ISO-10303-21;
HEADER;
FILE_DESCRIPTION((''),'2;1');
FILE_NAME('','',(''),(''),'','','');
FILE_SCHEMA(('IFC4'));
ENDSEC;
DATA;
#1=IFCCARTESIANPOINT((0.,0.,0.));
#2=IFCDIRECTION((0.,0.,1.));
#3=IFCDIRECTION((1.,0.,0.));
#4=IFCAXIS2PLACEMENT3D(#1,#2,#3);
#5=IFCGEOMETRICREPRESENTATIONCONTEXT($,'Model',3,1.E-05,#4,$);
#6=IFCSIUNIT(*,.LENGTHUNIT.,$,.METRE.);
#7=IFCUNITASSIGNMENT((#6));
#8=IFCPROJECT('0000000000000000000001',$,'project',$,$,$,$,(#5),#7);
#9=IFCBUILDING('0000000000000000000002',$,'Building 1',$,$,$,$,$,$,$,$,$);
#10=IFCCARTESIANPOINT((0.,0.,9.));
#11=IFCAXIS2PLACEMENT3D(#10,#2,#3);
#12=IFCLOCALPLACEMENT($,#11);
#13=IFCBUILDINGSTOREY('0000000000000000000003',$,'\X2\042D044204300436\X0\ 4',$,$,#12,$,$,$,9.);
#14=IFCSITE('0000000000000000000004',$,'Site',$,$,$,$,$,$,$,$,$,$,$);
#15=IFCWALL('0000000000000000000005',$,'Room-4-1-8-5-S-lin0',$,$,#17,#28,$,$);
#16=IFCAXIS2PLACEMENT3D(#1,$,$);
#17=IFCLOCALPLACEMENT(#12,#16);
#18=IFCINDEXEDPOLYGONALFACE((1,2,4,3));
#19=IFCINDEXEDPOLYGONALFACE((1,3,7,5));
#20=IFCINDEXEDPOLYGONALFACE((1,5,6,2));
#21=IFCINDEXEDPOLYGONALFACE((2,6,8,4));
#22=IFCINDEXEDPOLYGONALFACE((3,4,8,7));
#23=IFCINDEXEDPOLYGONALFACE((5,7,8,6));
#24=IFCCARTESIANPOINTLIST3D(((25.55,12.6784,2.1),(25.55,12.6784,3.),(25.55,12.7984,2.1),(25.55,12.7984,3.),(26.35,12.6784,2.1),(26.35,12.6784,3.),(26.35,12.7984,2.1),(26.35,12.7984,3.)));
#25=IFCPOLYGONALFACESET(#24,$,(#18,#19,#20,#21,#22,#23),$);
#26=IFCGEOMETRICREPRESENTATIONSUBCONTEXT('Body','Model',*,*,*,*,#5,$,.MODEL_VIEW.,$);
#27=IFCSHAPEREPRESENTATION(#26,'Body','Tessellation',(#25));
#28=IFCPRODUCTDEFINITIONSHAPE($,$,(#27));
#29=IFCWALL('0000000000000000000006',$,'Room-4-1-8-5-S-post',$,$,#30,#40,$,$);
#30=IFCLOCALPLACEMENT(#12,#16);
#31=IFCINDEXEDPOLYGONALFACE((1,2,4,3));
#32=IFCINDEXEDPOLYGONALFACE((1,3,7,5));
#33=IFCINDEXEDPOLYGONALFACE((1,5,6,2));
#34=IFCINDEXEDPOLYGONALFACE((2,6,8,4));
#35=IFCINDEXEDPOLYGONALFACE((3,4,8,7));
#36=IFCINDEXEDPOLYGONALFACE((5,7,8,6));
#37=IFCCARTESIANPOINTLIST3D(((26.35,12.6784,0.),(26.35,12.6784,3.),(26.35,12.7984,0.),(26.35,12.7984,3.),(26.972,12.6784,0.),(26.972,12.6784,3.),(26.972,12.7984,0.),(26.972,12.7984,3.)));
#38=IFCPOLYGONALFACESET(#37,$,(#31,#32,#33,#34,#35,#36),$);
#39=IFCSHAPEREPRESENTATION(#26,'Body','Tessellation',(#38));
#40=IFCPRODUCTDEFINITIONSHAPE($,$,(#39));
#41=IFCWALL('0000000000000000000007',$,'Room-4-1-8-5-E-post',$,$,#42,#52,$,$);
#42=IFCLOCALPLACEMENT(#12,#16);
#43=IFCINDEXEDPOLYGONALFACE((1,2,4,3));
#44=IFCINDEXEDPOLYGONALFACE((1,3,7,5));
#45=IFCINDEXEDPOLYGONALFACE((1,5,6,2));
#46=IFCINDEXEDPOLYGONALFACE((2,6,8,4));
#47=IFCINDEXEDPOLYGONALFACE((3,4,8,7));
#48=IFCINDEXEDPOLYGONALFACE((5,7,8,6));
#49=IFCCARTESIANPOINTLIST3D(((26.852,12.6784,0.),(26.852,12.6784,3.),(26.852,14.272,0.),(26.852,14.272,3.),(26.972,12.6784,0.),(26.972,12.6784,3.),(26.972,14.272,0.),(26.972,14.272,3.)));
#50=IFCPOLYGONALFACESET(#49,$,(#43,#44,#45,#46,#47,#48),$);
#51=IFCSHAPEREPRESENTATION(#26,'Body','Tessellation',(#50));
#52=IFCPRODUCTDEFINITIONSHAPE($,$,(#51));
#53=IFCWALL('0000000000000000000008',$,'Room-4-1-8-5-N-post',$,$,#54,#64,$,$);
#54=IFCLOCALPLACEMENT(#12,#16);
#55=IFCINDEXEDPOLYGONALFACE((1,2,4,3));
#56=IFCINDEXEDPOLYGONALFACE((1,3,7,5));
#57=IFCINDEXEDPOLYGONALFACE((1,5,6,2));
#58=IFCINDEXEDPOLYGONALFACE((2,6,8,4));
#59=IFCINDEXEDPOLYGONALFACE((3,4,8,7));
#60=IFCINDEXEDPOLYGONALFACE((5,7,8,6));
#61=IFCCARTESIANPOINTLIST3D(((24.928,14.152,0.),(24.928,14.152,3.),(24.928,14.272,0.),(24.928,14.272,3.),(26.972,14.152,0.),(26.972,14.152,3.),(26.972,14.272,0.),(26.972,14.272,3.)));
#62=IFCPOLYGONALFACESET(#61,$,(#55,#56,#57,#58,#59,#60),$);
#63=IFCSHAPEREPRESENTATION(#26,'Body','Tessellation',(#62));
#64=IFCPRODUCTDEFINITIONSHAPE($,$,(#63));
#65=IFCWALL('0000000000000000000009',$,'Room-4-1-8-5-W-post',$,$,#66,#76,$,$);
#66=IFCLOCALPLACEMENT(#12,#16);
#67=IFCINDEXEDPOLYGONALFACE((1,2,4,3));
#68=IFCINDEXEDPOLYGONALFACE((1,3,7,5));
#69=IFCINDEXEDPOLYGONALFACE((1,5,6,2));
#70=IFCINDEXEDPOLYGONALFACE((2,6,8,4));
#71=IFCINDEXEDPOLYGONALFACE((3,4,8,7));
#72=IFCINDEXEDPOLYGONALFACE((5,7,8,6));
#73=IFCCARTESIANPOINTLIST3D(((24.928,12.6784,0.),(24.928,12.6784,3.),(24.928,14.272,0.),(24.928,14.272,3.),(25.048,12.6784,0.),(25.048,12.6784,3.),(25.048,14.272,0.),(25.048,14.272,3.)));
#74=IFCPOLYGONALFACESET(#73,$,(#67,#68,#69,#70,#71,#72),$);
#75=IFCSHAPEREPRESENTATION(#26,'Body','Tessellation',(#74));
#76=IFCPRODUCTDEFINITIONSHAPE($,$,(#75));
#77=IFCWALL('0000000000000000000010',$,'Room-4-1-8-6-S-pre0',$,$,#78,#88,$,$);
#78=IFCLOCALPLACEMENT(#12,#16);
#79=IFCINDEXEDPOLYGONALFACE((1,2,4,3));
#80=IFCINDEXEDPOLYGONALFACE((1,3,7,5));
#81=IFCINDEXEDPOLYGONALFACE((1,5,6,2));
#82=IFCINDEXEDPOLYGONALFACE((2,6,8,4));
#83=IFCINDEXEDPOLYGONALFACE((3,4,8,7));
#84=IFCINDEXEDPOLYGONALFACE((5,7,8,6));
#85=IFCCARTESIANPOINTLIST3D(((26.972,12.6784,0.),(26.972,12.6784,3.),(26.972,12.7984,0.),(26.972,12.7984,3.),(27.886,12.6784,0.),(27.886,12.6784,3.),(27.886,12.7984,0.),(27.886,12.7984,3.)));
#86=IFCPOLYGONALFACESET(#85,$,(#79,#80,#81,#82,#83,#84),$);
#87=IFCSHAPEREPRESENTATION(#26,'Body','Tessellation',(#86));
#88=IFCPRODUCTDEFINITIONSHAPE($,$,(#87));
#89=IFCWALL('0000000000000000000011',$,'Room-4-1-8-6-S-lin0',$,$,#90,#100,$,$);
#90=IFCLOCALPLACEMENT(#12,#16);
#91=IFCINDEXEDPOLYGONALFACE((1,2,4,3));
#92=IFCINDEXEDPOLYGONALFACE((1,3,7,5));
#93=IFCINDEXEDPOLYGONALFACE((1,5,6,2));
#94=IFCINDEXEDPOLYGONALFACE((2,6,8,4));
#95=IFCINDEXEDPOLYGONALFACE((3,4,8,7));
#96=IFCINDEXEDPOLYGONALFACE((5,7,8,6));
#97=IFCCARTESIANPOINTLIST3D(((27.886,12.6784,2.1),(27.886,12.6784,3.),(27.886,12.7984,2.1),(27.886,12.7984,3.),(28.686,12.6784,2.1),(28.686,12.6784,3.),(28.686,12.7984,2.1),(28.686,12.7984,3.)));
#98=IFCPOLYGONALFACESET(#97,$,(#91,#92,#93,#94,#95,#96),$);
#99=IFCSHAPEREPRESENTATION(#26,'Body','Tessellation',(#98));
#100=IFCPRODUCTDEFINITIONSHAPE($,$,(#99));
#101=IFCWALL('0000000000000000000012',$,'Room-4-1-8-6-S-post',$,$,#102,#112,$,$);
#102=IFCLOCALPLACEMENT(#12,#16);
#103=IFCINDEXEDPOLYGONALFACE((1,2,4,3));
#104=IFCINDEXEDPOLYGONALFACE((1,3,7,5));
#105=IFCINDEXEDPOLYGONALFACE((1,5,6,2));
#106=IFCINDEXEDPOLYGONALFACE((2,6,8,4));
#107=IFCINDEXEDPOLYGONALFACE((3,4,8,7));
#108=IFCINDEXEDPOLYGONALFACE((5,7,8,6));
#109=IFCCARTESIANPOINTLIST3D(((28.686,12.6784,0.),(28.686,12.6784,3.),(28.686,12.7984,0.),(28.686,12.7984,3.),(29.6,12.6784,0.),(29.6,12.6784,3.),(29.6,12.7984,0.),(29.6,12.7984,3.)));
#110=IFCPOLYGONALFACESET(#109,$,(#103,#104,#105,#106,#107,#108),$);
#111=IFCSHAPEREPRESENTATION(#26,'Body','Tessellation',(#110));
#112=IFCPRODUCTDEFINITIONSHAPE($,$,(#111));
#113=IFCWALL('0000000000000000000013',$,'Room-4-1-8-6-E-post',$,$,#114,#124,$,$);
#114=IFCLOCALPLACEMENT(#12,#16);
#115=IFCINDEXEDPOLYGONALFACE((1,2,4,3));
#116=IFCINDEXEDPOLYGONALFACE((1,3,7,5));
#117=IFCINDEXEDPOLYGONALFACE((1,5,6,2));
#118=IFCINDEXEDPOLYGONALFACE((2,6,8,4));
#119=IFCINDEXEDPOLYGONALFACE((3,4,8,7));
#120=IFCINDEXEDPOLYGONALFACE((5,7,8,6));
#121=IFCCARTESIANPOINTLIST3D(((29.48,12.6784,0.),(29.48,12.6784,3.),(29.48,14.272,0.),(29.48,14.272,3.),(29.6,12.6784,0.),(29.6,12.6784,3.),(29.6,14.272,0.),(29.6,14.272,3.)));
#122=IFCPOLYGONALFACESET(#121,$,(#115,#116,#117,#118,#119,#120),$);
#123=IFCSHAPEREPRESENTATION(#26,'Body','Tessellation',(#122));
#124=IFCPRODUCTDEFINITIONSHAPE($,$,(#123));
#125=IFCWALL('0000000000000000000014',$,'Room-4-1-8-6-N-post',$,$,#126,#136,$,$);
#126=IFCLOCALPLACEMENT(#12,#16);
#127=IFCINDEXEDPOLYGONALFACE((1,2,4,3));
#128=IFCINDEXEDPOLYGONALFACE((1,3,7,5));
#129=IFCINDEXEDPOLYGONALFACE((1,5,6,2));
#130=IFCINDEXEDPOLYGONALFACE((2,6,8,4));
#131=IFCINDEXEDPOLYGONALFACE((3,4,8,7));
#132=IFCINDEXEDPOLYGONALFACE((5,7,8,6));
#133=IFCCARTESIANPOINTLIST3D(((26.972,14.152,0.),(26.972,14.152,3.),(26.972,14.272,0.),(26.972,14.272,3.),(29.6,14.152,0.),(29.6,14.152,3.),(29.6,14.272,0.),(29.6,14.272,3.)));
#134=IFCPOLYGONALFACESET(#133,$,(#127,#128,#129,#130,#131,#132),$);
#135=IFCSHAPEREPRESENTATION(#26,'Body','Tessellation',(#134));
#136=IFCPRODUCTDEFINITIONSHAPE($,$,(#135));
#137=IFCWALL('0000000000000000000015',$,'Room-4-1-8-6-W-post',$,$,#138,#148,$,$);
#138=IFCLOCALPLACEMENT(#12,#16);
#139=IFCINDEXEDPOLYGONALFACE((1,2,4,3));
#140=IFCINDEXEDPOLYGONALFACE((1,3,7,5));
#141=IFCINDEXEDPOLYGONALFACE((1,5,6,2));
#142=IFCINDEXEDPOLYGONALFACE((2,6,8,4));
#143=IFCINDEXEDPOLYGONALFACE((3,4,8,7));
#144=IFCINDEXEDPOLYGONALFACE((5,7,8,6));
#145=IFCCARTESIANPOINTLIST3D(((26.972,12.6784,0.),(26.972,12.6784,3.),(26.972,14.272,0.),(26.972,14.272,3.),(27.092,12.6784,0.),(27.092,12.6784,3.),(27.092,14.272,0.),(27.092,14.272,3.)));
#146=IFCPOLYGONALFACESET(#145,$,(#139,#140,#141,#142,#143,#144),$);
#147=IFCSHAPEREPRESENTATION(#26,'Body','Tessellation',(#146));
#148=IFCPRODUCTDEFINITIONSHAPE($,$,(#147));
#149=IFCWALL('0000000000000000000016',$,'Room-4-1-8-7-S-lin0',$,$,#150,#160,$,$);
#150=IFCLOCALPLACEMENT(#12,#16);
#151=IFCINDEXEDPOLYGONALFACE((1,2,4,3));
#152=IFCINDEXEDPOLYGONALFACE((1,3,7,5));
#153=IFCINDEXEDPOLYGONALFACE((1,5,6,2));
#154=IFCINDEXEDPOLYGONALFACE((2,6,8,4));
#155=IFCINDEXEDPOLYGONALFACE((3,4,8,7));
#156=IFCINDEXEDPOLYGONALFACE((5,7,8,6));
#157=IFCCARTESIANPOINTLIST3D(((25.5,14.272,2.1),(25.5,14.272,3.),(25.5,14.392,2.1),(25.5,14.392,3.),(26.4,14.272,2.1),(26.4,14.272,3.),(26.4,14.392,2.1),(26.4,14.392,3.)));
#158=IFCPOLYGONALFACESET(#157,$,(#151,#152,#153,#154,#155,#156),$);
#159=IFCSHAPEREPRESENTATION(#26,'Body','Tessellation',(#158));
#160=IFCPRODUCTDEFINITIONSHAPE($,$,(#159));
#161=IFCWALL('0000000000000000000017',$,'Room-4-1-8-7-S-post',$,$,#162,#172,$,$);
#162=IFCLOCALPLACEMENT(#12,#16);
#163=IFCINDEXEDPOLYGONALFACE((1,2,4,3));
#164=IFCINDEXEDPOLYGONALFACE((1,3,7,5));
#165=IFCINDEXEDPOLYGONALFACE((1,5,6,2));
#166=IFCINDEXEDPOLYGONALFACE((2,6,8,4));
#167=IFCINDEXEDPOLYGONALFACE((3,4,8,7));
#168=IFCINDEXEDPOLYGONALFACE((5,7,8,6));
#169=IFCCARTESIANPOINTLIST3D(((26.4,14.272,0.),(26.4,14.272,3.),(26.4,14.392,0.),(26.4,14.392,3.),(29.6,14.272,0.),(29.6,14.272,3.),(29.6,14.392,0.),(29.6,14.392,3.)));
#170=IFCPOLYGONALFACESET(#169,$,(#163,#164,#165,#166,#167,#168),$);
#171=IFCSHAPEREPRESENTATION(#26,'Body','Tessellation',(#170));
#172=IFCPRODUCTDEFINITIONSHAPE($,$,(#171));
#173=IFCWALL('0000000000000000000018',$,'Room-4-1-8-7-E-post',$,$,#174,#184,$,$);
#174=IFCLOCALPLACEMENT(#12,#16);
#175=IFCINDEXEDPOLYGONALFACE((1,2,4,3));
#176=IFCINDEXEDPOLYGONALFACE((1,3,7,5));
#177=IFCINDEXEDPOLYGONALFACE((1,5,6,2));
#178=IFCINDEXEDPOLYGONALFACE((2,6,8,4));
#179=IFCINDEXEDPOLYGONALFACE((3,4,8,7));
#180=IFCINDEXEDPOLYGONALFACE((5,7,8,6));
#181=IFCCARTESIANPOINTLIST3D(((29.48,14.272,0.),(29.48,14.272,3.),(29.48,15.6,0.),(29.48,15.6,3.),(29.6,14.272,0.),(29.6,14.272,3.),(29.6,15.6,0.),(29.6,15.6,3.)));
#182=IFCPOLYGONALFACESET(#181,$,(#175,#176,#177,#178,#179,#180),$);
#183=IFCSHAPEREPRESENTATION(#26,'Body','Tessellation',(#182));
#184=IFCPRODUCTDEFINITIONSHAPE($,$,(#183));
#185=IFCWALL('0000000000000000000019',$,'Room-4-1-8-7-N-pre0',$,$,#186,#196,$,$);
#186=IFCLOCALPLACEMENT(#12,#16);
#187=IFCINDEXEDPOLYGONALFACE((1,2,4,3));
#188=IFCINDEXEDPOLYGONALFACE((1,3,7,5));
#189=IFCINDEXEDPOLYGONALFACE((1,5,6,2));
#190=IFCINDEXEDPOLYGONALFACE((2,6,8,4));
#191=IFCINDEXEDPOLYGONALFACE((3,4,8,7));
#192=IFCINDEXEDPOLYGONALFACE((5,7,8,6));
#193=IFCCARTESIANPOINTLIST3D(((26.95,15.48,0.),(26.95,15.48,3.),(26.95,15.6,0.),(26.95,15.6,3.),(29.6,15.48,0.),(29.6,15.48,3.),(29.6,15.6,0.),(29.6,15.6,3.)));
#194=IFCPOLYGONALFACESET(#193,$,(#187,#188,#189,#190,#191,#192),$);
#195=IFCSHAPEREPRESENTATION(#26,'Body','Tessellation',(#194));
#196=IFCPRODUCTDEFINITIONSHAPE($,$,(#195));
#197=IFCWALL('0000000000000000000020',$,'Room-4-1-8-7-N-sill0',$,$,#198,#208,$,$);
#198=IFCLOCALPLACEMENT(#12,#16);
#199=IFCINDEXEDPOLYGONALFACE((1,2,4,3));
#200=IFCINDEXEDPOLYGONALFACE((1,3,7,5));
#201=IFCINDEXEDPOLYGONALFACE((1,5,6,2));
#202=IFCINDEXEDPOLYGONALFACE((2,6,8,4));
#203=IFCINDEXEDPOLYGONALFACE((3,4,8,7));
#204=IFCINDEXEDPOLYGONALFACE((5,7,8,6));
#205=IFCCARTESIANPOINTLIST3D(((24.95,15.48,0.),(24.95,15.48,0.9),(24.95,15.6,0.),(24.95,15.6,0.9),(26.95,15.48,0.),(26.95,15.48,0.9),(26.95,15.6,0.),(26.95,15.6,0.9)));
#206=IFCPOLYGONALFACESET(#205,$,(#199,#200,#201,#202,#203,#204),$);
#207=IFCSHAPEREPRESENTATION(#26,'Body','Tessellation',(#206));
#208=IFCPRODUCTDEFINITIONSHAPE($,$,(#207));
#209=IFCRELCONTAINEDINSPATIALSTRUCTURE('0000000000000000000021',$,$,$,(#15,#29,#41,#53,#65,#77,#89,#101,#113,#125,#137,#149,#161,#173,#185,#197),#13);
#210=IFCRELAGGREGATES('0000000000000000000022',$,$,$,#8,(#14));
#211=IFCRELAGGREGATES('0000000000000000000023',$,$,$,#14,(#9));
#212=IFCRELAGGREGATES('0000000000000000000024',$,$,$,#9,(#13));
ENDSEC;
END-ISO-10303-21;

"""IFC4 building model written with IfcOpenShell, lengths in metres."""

from ifc_helpers import new_model, si_unit, frame, origin_with_axes, place, context, subcontext, project, spatial, indexed_curve, outline, extrude, element, save


model = new_model("IFC4")

# Units and contexts
model_context = context("Model", 3, precision=1e-05, world=origin_with_axes())
body_context = subcontext(model_context, "Body", "Model", "MODEL_VIEW")
ifc_project = project(units=[si_unit("LENGTHUNIT", "METRE")], contexts=[model_context])

# Site, building, storey
site = spatial("IfcSite", under=ifc_project, Name="Site")
building = spatial("IfcBuilding", under=site, Name="Building 1")
storey_placement = place(None, frame((0.0, 0.0, 9.0), z_axis=(0.0, 0.0, 1.0), x_axis=(1.0, 0.0, 0.0)))
storey = spatial("IfcBuildingStorey", under=building, at=storey_placement, Name="Этаж 4", Elevation=9.0)

# Walls
wall_1_placement = place(storey_placement, frame((25.55, 12.6784, 2.1), z_axis=(0.0, 0.0, 1.0), x_axis=(1.0, 0.0, 0.0)))
element("IfcWall", 1, at=wall_1_placement, inside=storey, Name="Room-4-1-8-5-S-lin0", context=body_context, shape_type="SweptSolid", body=[
    extrude(outline(indexed_curve([(0.0, 0.0), (0.0, 0.12), (0.8, 0.12), (0.8, 0.0), (0.0, 0.0)], self_intersect=False)), origin_with_axes(), (0.0, 0.0, 1.0), 0.9),
])
wall_2_placement = place(storey_placement, frame((26.35, 12.6784, 0.0), z_axis=(0.0, 0.0, 1.0), x_axis=(1.0, 0.0, 0.0)))
element("IfcWall", 2, at=wall_2_placement, inside=storey, Name="Room-4-1-8-5-S-post", context=body_context, shape_type="SweptSolid", body=[
    extrude(outline(indexed_curve([(0.0, 0.0), (0.0, 0.12), (0.622, 0.12), (0.622, 0.0), (0.0, 0.0)], self_intersect=False)), origin_with_axes(), (0.0, 0.0, 1.0), 3.0),
])
wall_3_placement = place(storey_placement, frame((26.972, 12.6784, 0.0), z_axis=(0.0, 0.0, 1.0), x_axis=(0.0, 1.0, 0.0)))
element("IfcWall", 3, at=wall_3_placement, inside=storey, Name="Room-4-1-8-5-E-post", context=body_context, shape_type="SweptSolid", body=[
    extrude(outline(indexed_curve([(0.0, 0.0), (0.0, 0.12), (1.5936, 0.12), (1.5936, 0.0), (0.0, 0.0)], self_intersect=False)), origin_with_axes(), (0.0, 0.0, 1.0), 3.0),
])
wall_4_placement = place(storey_placement, frame((26.972, 14.272, 0.0), z_axis=(0.0, 0.0, 1.0), x_axis=(-1.0, 0.0, 0.0)))
element("IfcWall", 4, at=wall_4_placement, inside=storey, Name="Room-4-1-8-5-N-post", context=body_context, shape_type="SweptSolid", body=[
    extrude(outline(indexed_curve([(0.0, 0.0), (0.0, 0.12), (2.044, 0.12), (2.044, 0.0), (0.0, 0.0)], self_intersect=False)), origin_with_axes(), (0.0, 0.0, 1.0), 3.0),
])
wall_5_placement = place(storey_placement, frame((24.928, 14.272, 0.0), z_axis=(0.0, 0.0, 1.0), x_axis=(0.0, -1.0, 0.0)))
element("IfcWall", 5, at=wall_5_placement, inside=storey, Name="Room-4-1-8-5-W-post", context=body_context, shape_type="SweptSolid", body=[
    extrude(outline(indexed_curve([(0.0, 0.0), (0.0, 0.12), (1.5936, 0.12), (1.5936, 0.0), (0.0, 0.0)], self_intersect=False)), origin_with_axes(), (0.0, 0.0, 1.0), 3.0),
])
wall_6_placement = place(storey_placement, frame((26.972, 12.6784, 0.0), z_axis=(0.0, 0.0, 1.0), x_axis=(1.0, 0.0, 0.0)))
element("IfcWall", 6, at=wall_6_placement, inside=storey, Name="Room-4-1-8-6-S-pre0", context=body_context, shape_type="SweptSolid", body=[
    extrude(outline(indexed_curve([(0.0, 0.0), (0.0, 0.12), (0.914, 0.12), (0.914, 0.0), (0.0, 0.0)], self_intersect=False)), origin_with_axes(), (0.0, 0.0, 1.0), 3.0),
])
wall_7_placement = place(storey_placement, frame((27.886, 12.6784, 2.1), z_axis=(0.0, 0.0, 1.0), x_axis=(1.0, 0.0, 0.0)))
element("IfcWall", 7, at=wall_7_placement, inside=storey, Name="Room-4-1-8-6-S-lin0", context=body_context, shape_type="SweptSolid", body=[
    extrude(outline(indexed_curve([(0.0, 0.0), (0.0, 0.12), (0.8, 0.12), (0.8, 0.0), (0.0, 0.0)], self_intersect=False)), origin_with_axes(), (0.0, 0.0, 1.0), 0.9),
])
wall_8_placement = place(storey_placement, frame((28.686, 12.6784, 0.0), z_axis=(0.0, 0.0, 1.0), x_axis=(1.0, 0.0, 0.0)))
element("IfcWall", 8, at=wall_8_placement, inside=storey, Name="Room-4-1-8-6-S-post", context=body_context, shape_type="SweptSolid", body=[
    extrude(outline(indexed_curve([(0.0, 0.0), (0.0, 0.12), (0.914, 0.12), (0.914, 0.0), (0.0, 0.0)], self_intersect=False)), origin_with_axes(), (0.0, 0.0, 1.0), 3.0),
])
wall_9_placement = place(storey_placement, frame((29.6, 12.6784, 0.0), z_axis=(0.0, 0.0, 1.0), x_axis=(0.0, 1.0, 0.0)))
element("IfcWall", 9, at=wall_9_placement, inside=storey, Name="Room-4-1-8-6-E-post", context=body_context, shape_type="SweptSolid", body=[
    extrude(outline(indexed_curve([(0.0, 0.0), (0.0, 0.12), (1.5936, 0.12), (1.5936, 0.0), (0.0, 0.0)], self_intersect=False)), origin_with_axes(), (0.0, 0.0, 1.0), 3.0),
])
wall_10_placement = place(storey_placement, frame((29.6, 14.272, 0.0), z_axis=(0.0, 0.0, 1.0), x_axis=(-1.0, 0.0, 0.0)))
element("IfcWall", 10, at=wall_10_placement, inside=storey, Name="Room-4-1-8-6-N-post", context=body_context, shape_type="SweptSolid", body=[
    extrude(outline(indexed_curve([(0.0, 0.0), (0.0, 0.12), (2.628, 0.12), (2.628, 0.0), (0.0, 0.0)], self_intersect=False)), origin_with_axes(), (0.0, 0.0, 1.0), 3.0),
])
wall_11_placement = place(storey_placement, frame((26.972, 14.272, 0.0), z_axis=(0.0, 0.0, 1.0), x_axis=(0.0, -1.0, 0.0)))
element("IfcWall", 11, at=wall_11_placement, inside=storey, Name="Room-4-1-8-6-W-post", context=body_context, shape_type="SweptSolid", body=[
    extrude(outline(indexed_curve([(0.0, 0.0), (0.0, 0.12), (1.5936, 0.12), (1.5936, 0.0), (0.0, 0.0)], self_intersect=False)), origin_with_axes(), (0.0, 0.0, 1.0), 3.0),
])
wall_12_placement = place(storey_placement, frame((25.5, 14.272, 2.1), z_axis=(0.0, 0.0, 1.0), x_axis=(1.0, 0.0, 0.0)))
element("IfcWall", 12, at=wall_12_placement, inside=storey, Name="Room-4-1-8-7-S-lin0", context=body_context, shape_type="SweptSolid", body=[
    extrude(outline(indexed_curve([(0.0, 0.0), (0.0, 0.12), (0.9, 0.12), (0.9, 0.0), (0.0, 0.0)], self_intersect=False)), origin_with_axes(), (0.0, 0.0, 1.0), 0.9),
])
wall_13_placement = place(storey_placement, frame((26.4, 14.272, 0.0), z_axis=(0.0, 0.0, 1.0), x_axis=(1.0, 0.0, 0.0)))
element("IfcWall", 13, at=wall_13_placement, inside=storey, Name="Room-4-1-8-7-S-post", context=body_context, shape_type="SweptSolid", body=[
    extrude(outline(indexed_curve([(0.0, 0.0), (0.0, 0.12), (3.2, 0.12), (3.2, 0.0), (0.0, 0.0)], self_intersect=False)), origin_with_axes(), (0.0, 0.0, 1.0), 3.0),
])
wall_14_placement = place(storey_placement, frame((29.6, 14.272, 0.0), z_axis=(0.0, 0.0, 1.0), x_axis=(0.0, 1.0, 0.0)))
element("IfcWall", 14, at=wall_14_placement, inside=storey, Name="Room-4-1-8-7-E-post", context=body_context, shape_type="SweptSolid", body=[
    extrude(outline(indexed_curve([(0.0, 0.0), (0.0, 0.12), (1.328, 0.12), (1.328, 0.0), (0.0, 0.0)], self_intersect=False)), origin_with_axes(), (0.0, 0.0, 1.0), 3.0),
])
wall_15_placement = place(storey_placement, frame((29.6, 15.6, 0.0), z_axis=(0.0, 0.0, 1.0), x_axis=(-1.0, 0.0, 0.0)))
element("IfcWall", 15, at=wall_15_placement, inside=storey, Name="Room-4-1-8-7-N-pre0", context=body_context, shape_type="SweptSolid", body=[
    extrude(outline(indexed_curve([(0.0, 0.0), (0.0, 0.12), (2.65, 0.12), (2.65, 0.0), (0.0, 0.0)], self_intersect=False)), origin_with_axes(), (0.0, 0.0, 1.0), 3.0),
])
wall_16_placement = place(storey_placement, frame((26.95, 15.6, 0.0), z_axis=(0.0, 0.0, 1.0), x_axis=(-1.0, 0.0, 0.0)))
element("IfcWall", 16, at=wall_16_placement, inside=storey, Name="Room-4-1-8-7-N-sill0", context=body_context, shape_type="SweptSolid", body=[
    extrude(outline(indexed_curve([(0.0, 0.0), (0.0, 0.12), (2.0, 0.12), (2.0, 0.0), (0.0, 0.0)], self_intersect=False)), origin_with_axes(), (0.0, 0.0, 1.0), 0.9),
])

save(model, "model.ifc")
